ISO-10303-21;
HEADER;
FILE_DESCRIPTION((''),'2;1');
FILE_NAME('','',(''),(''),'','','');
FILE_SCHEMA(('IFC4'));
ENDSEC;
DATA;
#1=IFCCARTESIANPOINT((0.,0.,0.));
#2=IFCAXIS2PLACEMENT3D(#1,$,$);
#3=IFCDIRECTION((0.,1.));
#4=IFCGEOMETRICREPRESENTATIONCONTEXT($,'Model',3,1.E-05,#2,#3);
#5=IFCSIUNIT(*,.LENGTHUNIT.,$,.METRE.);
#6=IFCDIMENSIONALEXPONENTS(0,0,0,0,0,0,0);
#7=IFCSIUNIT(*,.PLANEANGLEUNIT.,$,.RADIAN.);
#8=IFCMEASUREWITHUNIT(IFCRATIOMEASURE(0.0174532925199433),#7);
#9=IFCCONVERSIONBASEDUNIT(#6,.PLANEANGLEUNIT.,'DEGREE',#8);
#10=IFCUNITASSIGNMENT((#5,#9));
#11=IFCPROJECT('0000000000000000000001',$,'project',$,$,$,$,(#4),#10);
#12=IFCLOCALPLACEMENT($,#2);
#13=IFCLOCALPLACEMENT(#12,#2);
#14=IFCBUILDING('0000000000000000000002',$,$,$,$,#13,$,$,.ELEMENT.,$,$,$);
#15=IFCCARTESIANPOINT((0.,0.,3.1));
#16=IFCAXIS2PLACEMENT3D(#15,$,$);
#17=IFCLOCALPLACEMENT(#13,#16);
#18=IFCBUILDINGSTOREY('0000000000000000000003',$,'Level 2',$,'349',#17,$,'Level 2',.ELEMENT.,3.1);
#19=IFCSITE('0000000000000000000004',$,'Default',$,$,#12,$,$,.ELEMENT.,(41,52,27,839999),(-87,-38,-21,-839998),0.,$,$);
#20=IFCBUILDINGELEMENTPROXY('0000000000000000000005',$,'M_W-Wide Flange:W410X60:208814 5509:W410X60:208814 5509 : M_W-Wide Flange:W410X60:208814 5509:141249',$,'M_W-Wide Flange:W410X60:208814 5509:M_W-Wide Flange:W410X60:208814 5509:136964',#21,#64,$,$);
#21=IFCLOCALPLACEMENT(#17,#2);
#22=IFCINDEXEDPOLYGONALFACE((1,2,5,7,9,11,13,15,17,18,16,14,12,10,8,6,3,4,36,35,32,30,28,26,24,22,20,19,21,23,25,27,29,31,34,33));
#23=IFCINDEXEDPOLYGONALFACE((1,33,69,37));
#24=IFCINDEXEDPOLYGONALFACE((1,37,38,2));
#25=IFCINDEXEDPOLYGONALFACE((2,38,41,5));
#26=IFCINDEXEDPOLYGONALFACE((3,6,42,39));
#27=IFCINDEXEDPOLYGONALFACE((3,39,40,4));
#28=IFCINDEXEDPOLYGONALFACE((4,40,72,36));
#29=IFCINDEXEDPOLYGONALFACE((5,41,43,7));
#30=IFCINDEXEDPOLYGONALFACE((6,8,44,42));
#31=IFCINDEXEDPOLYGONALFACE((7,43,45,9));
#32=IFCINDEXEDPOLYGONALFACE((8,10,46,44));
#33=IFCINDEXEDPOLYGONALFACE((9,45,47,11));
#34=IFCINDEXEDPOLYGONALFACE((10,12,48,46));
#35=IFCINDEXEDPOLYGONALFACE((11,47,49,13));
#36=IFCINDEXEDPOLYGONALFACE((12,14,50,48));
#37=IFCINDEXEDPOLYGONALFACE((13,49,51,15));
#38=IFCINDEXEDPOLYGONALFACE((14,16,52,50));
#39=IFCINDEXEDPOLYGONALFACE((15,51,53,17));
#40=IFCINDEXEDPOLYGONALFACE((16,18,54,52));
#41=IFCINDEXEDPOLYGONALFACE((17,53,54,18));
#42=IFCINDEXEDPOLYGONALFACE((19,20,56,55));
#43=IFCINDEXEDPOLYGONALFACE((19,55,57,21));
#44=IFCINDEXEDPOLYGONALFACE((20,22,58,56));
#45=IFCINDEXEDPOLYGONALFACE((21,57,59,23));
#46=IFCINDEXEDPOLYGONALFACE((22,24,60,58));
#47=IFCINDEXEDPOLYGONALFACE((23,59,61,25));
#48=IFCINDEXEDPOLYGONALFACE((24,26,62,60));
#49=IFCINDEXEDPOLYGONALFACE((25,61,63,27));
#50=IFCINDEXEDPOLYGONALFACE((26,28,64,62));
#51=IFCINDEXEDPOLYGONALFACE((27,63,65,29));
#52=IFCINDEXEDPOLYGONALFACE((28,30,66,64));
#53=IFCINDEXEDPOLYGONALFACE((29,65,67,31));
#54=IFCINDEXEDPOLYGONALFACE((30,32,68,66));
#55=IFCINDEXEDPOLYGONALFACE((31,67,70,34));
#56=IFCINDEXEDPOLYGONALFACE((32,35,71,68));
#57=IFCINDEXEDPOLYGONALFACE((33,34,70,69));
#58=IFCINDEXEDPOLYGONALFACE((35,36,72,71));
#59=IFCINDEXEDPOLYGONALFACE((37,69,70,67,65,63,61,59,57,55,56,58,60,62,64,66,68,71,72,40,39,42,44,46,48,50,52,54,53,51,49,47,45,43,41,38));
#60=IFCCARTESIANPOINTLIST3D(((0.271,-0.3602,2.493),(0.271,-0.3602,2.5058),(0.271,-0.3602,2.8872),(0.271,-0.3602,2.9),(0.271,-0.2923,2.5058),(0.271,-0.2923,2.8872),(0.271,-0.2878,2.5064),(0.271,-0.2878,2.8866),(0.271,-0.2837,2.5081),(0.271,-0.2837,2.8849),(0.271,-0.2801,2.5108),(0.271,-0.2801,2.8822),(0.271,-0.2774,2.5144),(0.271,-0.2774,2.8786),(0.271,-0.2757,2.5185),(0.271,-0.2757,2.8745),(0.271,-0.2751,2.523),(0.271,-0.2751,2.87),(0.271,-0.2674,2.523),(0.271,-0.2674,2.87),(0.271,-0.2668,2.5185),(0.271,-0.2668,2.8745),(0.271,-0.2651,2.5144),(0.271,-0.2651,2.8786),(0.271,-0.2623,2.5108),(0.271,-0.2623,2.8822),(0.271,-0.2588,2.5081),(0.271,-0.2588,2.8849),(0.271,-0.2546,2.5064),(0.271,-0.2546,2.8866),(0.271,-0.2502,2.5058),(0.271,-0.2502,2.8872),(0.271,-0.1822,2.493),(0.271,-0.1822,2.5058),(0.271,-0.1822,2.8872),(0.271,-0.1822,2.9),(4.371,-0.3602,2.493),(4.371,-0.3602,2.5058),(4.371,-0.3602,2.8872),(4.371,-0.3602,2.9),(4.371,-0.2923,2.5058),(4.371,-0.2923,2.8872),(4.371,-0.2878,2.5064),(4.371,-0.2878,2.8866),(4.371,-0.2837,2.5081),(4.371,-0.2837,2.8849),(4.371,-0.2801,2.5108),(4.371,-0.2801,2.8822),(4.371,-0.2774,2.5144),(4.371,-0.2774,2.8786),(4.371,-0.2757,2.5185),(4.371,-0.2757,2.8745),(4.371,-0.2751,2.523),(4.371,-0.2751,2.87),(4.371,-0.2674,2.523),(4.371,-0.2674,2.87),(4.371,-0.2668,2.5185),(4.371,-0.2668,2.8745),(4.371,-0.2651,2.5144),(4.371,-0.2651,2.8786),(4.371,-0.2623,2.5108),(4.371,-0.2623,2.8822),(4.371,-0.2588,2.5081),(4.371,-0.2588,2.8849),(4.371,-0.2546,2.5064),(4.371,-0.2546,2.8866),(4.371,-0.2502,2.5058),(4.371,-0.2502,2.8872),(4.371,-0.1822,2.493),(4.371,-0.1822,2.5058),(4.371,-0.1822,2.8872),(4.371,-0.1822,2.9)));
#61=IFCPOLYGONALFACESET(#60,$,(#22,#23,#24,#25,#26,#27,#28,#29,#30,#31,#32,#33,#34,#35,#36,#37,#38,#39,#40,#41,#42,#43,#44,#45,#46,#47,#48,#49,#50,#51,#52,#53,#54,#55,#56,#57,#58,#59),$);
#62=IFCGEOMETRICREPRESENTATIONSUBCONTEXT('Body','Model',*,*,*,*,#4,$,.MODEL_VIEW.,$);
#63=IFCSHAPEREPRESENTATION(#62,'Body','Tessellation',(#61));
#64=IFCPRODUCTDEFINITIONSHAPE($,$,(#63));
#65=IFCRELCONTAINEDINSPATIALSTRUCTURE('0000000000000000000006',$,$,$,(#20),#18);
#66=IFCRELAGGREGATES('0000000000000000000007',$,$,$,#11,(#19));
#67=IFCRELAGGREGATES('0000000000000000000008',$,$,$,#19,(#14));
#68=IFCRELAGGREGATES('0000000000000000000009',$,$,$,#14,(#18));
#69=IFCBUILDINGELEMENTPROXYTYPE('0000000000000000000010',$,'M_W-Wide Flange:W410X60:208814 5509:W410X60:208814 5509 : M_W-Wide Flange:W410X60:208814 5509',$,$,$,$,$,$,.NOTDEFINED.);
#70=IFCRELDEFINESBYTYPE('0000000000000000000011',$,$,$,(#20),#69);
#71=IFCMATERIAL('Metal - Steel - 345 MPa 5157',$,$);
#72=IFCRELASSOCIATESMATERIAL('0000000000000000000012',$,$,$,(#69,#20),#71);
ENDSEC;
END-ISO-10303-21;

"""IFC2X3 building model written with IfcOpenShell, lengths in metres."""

from ifc_helpers import new_model, entity, si_unit, converted_unit, direction, frame, frame_2d, origin, place, context, subcontext, project, spatial, i_section, extrude, source, transform, mapped, material, type_object, type_shapes, element, save


model = new_model("IFC2X3")

# Units and contexts
model_context = context("Model", 3, precision=1e-05, world=origin(), true_north=direction((0.0, 1.0)))
body_context = subcontext(model_context, "Body", "Model", "MODEL_VIEW")
ifc_project = project(units=[si_unit("LENGTHUNIT", "METRE"), converted_unit("PLANEANGLEUNIT", "DEGREE", entity("IfcRatioMeasure", 0.0174532925199433), si_unit("PLANEANGLEUNIT", "RADIAN"), dimensions=[0, 0, 0, 0, 0, 0, 0])], contexts=[model_context])

# Site, building, storey
site_placement = place(None, origin())
site = spatial("IfcSite", under=ifc_project, at=site_placement, Name="Default", CompositionType="ELEMENT", RefLatitude=(41, 52, 27, 839999), RefLongitude=(-87, -38, -21, -839998), RefElevation=0.0)
building_placement = place(site_placement, origin())
building = spatial("IfcBuilding", under=site, at=building_placement, CompositionType="ELEMENT")
storey_placement = place(building_placement, frame((0.0, 0.0, 3.1)))
storey = spatial("IfcBuildingStorey", under=building, at=storey_placement, Name="Level 2", ObjectType="349", LongName="Level 2", CompositionType="ELEMENT", Elevation=3.1)

# Building element proxy
ifc_material_1 = material(Name="Metal - Steel - 345 MPa 5157")
building_element_proxy_type_1 = type_object("IfcBuildingElementProxyType", Name="M_W-Wide Flange:W410X60:208814 5509:W410X60:208814 5509 : M_W-Wide Flange:W410X60:208814 5509", PredefinedType="NOTDEFINED", material=ifc_material_1)
shared_shape_1 = source(origin(), body_context, "Body", "SweptSolid", [
    extrude(i_section(OverallWidth=0.178, OverallDepth=0.407, WebThickness=0.0077, FlangeThickness=0.0128, FilletRadius=0.0172, at=frame_2d((0.0, 0.0), x_axis=(0.0, 1.0))), frame((0.0, 0.0, -0.2035), z_axis=(0.0, 1.0, 0.0), x_axis=(0.0, 0.0, 1.0)), (0.0, 0.0, 1.0), 4.1),
])
type_shapes(building_element_proxy_type_1, [shared_shape_1])
proxy_1_placement = place(storey_placement, frame((4.371, -0.2712, 2.9), z_axis=(0.0, 0.0, 1.0), x_axis=(0.0, 1.0, 0.0)))
element("IfcBuildingElementProxy", 1, at=proxy_1_placement, inside=storey, type_object=building_element_proxy_type_1, material=ifc_material_1, Name="M_W-Wide Flange:W410X60:208814 5509:W410X60:208814 5509 : M_W-Wide Flange:W410X60:208814 5509:141249", ObjectType="M_W-Wide Flange:W410X60:208814 5509:M_W-Wide Flange:W410X60:208814 5509:136964", context=body_context, shape_type="MappedRepresentation", body=[
    mapped(shared_shape_1, transform((0.0, 0.0, 0.0), scale=1.0)),
])

save(model, "model.ifc")
